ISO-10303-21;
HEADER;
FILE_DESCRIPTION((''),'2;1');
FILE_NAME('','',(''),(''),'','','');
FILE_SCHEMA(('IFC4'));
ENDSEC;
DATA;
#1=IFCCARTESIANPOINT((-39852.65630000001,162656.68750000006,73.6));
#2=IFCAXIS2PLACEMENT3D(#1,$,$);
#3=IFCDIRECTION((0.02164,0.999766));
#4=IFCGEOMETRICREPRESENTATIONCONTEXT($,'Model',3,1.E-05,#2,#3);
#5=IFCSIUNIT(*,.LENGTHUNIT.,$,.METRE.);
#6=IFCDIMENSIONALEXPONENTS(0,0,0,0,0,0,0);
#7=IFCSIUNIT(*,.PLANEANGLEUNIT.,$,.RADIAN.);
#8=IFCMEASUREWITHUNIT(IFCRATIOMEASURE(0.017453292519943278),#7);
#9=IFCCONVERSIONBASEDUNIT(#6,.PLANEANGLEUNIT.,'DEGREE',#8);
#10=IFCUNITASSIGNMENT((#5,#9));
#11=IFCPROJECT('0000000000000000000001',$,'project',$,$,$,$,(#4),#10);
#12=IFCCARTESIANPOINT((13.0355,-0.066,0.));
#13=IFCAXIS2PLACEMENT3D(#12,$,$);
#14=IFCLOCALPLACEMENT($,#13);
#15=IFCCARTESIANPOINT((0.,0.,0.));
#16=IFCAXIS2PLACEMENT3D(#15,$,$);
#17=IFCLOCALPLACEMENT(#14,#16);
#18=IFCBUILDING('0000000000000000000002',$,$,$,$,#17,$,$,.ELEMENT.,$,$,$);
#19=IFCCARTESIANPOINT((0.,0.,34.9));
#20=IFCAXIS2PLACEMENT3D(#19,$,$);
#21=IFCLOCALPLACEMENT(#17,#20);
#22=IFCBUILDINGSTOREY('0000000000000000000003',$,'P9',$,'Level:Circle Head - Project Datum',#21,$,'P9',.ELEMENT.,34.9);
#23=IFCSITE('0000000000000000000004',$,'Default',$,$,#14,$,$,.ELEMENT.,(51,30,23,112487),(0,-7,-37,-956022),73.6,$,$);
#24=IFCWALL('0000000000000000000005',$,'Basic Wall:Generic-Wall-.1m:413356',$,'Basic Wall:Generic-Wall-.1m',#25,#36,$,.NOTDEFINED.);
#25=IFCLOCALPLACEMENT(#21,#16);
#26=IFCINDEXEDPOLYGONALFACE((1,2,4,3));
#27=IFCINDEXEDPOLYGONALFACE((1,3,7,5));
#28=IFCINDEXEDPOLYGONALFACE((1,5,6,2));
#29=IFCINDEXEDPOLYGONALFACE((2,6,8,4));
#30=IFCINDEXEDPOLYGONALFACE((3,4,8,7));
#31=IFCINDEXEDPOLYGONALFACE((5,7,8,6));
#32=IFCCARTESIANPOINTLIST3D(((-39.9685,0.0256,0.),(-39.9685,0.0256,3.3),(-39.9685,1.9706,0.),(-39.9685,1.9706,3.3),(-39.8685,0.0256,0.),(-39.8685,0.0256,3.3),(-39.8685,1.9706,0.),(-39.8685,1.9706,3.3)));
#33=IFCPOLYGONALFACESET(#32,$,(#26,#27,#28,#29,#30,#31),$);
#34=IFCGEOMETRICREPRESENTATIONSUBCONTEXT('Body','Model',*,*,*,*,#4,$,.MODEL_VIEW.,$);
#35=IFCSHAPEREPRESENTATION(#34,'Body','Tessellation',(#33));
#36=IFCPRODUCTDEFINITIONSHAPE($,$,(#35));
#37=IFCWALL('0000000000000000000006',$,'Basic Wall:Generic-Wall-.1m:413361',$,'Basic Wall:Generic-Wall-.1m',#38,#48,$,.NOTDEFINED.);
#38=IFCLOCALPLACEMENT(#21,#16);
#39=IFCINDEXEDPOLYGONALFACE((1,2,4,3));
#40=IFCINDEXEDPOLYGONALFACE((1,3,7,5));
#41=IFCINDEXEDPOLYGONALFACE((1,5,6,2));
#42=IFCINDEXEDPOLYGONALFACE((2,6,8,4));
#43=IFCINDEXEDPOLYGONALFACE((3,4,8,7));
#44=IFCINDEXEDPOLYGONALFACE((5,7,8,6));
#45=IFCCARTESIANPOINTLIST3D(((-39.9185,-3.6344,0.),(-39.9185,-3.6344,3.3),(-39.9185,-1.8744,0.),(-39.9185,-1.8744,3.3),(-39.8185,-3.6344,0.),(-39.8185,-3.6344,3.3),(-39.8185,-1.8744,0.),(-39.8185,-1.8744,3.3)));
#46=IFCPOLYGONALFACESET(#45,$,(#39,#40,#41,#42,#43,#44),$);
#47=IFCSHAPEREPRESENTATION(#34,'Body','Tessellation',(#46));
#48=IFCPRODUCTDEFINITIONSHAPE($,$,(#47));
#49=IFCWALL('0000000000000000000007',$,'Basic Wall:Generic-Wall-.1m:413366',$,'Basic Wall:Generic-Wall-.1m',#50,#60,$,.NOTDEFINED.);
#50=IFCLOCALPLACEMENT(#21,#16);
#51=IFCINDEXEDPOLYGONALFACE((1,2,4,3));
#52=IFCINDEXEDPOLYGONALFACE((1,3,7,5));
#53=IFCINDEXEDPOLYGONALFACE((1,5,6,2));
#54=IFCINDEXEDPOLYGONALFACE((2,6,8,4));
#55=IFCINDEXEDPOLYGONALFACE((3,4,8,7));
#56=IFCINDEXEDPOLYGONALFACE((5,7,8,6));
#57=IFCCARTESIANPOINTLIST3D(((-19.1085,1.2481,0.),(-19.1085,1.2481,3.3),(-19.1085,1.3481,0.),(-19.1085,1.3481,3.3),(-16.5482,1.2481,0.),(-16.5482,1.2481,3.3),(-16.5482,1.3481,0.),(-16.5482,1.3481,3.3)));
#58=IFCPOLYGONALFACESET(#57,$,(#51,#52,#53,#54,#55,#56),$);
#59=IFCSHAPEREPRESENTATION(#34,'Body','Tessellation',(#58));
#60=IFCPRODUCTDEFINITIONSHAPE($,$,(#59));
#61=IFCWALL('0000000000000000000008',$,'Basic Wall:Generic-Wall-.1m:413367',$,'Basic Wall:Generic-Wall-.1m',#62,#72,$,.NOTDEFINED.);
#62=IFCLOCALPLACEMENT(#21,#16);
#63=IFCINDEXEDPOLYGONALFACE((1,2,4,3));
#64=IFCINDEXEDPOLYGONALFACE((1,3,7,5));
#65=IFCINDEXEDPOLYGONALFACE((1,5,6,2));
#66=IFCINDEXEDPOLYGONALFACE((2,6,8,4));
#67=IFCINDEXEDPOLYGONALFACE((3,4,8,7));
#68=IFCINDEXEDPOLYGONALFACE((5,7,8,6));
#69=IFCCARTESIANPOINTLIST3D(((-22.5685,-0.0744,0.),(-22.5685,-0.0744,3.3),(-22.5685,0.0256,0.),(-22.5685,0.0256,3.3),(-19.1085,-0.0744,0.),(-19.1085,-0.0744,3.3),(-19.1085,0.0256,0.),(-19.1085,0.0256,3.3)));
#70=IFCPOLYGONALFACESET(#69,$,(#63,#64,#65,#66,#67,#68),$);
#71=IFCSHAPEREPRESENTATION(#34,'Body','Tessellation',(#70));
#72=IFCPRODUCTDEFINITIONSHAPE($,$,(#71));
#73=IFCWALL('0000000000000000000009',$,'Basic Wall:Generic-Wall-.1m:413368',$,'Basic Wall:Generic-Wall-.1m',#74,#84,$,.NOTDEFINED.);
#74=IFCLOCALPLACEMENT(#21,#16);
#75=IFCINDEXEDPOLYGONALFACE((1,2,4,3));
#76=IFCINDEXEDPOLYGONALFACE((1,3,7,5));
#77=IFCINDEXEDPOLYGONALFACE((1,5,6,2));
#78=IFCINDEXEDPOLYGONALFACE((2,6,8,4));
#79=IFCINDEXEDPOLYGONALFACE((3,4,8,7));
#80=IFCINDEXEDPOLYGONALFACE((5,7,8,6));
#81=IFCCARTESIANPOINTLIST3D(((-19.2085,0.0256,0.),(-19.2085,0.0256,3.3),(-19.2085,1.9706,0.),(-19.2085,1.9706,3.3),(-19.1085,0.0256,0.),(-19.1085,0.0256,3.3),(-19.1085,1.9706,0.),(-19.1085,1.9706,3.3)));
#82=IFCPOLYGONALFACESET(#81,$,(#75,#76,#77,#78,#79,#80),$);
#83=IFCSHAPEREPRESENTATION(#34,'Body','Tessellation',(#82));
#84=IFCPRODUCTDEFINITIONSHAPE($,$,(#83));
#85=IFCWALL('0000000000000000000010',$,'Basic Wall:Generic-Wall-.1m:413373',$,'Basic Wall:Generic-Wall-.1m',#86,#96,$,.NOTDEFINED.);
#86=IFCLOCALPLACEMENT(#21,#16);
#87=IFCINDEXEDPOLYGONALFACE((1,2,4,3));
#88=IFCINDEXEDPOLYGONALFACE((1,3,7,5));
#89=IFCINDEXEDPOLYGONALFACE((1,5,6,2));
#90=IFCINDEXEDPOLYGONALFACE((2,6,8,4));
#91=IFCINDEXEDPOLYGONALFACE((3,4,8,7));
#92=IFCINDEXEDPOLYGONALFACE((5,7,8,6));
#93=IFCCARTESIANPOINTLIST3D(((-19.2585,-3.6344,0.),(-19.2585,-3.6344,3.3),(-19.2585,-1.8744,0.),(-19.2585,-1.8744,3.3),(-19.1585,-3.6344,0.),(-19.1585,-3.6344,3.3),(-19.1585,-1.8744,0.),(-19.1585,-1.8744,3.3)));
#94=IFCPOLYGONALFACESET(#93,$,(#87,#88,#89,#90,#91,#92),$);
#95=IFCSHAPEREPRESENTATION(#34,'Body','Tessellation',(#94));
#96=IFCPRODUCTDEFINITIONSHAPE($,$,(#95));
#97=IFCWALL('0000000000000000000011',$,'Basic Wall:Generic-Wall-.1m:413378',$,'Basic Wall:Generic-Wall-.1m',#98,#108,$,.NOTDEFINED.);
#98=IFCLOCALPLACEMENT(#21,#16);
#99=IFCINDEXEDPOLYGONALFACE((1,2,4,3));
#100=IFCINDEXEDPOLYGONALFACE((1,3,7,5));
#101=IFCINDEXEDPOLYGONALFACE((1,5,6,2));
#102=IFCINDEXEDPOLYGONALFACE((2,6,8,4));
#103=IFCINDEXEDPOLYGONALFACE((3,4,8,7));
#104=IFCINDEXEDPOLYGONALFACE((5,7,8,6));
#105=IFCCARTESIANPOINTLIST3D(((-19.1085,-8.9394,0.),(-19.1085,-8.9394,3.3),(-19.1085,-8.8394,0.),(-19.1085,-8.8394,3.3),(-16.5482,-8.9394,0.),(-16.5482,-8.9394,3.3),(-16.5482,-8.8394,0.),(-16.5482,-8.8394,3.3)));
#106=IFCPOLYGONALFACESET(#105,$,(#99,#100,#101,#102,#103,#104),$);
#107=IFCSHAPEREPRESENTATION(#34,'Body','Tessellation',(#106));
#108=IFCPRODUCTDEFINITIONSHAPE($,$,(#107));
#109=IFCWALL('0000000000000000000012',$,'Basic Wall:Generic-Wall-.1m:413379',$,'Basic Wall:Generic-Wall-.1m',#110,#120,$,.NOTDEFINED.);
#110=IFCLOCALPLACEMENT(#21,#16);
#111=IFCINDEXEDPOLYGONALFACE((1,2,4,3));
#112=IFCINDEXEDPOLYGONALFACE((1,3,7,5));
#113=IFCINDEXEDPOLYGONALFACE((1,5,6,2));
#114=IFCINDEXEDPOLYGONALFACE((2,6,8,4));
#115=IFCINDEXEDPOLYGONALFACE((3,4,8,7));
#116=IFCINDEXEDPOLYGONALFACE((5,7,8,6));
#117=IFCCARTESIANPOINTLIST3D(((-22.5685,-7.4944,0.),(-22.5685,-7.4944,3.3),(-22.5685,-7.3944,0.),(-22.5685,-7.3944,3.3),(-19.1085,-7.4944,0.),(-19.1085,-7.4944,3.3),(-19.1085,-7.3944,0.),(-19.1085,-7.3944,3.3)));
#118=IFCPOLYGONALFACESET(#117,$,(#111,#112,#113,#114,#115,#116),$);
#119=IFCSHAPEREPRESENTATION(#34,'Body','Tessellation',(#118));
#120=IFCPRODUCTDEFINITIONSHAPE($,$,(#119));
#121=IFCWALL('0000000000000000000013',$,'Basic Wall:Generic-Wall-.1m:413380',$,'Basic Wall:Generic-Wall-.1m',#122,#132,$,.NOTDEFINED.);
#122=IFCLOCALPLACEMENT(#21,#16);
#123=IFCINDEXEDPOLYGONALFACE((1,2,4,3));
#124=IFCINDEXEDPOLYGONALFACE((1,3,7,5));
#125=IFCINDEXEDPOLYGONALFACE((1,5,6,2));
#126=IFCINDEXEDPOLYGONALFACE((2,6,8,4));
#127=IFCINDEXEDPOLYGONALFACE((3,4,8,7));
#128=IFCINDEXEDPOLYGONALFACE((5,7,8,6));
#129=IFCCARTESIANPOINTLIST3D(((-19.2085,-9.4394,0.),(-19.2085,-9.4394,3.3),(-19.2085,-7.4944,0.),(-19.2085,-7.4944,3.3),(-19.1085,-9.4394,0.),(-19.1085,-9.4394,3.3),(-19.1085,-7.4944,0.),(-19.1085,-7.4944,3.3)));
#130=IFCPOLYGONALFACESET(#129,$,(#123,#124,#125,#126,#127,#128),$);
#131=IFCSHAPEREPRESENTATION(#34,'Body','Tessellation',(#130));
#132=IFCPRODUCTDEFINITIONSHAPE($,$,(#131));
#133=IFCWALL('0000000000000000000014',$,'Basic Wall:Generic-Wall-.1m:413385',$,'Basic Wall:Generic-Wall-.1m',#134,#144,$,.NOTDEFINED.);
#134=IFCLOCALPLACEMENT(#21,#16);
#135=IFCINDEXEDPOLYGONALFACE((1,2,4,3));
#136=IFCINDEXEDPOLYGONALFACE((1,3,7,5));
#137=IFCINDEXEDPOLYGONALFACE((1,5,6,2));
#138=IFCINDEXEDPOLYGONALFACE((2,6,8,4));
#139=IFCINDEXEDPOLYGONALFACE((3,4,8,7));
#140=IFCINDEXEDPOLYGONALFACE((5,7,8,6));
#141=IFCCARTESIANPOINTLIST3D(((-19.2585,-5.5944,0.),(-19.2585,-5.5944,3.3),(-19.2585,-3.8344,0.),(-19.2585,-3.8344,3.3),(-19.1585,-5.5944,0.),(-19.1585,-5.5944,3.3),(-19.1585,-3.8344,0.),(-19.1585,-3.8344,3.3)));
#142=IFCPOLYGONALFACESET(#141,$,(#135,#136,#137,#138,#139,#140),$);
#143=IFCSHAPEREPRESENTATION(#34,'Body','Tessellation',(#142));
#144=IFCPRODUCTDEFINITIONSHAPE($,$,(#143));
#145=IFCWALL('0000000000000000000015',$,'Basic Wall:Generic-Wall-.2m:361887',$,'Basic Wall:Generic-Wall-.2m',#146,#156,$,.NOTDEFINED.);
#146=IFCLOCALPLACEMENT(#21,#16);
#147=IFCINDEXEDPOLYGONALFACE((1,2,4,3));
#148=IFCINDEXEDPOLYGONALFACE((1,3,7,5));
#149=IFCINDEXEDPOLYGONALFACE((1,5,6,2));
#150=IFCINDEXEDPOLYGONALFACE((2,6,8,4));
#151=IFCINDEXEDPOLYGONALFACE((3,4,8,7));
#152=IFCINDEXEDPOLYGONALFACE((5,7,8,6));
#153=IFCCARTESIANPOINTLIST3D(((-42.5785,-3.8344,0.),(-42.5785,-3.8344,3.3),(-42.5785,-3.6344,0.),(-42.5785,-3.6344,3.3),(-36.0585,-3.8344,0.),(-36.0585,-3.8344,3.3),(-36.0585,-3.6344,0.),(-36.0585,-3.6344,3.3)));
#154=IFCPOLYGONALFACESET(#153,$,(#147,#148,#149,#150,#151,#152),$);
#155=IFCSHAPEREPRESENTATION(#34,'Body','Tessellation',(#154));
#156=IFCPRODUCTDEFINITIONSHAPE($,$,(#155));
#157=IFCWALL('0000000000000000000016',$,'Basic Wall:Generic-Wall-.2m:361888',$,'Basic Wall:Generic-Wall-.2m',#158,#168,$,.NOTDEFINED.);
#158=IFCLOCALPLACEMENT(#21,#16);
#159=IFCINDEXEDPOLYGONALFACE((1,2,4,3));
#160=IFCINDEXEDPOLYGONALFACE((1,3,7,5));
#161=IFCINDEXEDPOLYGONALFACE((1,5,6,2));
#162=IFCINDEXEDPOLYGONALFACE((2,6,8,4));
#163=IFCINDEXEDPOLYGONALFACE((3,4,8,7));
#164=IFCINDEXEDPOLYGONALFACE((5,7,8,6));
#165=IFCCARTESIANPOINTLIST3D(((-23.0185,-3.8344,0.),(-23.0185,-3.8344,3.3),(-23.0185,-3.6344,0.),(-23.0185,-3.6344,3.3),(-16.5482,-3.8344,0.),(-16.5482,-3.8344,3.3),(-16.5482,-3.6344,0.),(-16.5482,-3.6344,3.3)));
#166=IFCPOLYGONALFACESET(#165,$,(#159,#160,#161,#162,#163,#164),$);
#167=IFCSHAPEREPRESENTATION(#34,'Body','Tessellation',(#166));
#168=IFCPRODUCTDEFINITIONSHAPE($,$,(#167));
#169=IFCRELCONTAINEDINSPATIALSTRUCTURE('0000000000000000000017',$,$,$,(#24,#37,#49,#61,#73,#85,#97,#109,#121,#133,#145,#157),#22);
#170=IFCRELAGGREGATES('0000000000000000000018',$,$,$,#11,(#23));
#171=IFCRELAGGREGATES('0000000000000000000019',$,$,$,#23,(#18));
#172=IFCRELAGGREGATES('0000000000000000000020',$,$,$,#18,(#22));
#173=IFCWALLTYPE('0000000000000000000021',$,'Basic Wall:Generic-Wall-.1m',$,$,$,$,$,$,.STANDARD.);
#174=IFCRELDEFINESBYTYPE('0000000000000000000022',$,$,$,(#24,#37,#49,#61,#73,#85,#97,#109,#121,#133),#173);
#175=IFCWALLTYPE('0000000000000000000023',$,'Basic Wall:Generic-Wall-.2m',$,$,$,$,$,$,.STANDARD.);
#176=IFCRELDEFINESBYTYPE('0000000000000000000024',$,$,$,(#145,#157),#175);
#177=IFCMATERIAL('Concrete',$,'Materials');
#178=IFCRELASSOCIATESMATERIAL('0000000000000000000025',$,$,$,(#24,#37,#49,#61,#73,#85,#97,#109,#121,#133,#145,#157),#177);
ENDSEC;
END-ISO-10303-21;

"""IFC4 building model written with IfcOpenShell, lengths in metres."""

from ifc_helpers import new_model, entity, si_unit, converted_unit, direction, frame, origin, place, context, subcontext, project, spatial, indexed_curve, outline, extrude, material, type_object, element, save


model = new_model("IFC4")

# Units and contexts
model_context = context("Model", 3, precision=1e-05, world=frame((-39852.65630000001, 162656.68750000006, 73.6)), true_north=direction((0.02164, 0.999766)))
body_context = subcontext(model_context, "Body", "Model", "MODEL_VIEW")
ifc_project = project(units=[si_unit("LENGTHUNIT", "METRE"), converted_unit("PLANEANGLEUNIT", "DEGREE", entity("IfcRatioMeasure", 0.017453292519943278), si_unit("PLANEANGLEUNIT", "RADIAN"), dimensions=[0, 0, 0, 0, 0, 0, 0])], contexts=[model_context])

# Site, building, storey
site_placement = place(None, frame((13.0355, -0.066, 0.0)))
site = spatial("IfcSite", under=ifc_project, at=site_placement, Name="Default", CompositionType="ELEMENT", RefLatitude=(51, 30, 23, 112487), RefLongitude=(0, -7, -37, -956022), RefElevation=73.6)
building_placement = place(site_placement, origin())
building = spatial("IfcBuilding", under=site, at=building_placement, CompositionType="ELEMENT")
storey_placement = place(building_placement, frame((0.0, 0.0, 34.9)))
storey = spatial("IfcBuildingStorey", under=building, at=storey_placement, Name="P9", ObjectType="Level:Circle Head - Project Datum", LongName="P9", CompositionType="ELEMENT", Elevation=34.9)

# Shared definitions
ifc_material = material(Name="Concrete", Category="Materials")

# Walls
wall_type_1 = type_object("IfcWallType", Name="Basic Wall:Generic-Wall-.1m", PredefinedType="STANDARD")
wall_1_placement = place(storey_placement, frame((-39.9185, 0.0256, 0.0), z_axis=(0.0, 0.0, 1.0), x_axis=(0.0, 1.0, 0.0)))
element("IfcWall", 1, at=wall_1_placement, inside=storey, type_object=wall_type_1, material=ifc_material, Name="Basic Wall:Generic-Wall-.1m:413356", ObjectType="Basic Wall:Generic-Wall-.1m", PredefinedType="NOTDEFINED", context=body_context, shape_type="SweptSolid", body=[
    extrude(outline(indexed_curve([(1.945, 0.05), (0.0, 0.05), (0.0, -0.05), (1.945, -0.05), (1.945, 0.05)], self_intersect=False)), origin(), (0.0, 0.0, 1.0), 3.3),
])
wall_2_placement = place(storey_placement, frame((-39.8685, -1.8744, 0.0), z_axis=(0.0, 0.0, 1.0), x_axis=(0.0, -1.0, 0.0)))
element("IfcWall", 2, at=wall_2_placement, inside=storey, type_object=wall_type_1, material=ifc_material, Name="Basic Wall:Generic-Wall-.1m:413361", ObjectType="Basic Wall:Generic-Wall-.1m", PredefinedType="NOTDEFINED", context=body_context, shape_type="SweptSolid", body=[
    extrude(outline(indexed_curve([(1.76, 0.05), (0.0, 0.05), (0.0, -0.05), (1.76, -0.05), (1.76, 0.05)], self_intersect=False)), origin(), (0.0, 0.0, 1.0), 3.3),
])
wall_3_placement = place(storey_placement, frame((-19.1085, 1.2981, 0.0)))
element("IfcWall", 3, at=wall_3_placement, inside=storey, type_object=wall_type_1, material=ifc_material, Name="Basic Wall:Generic-Wall-.1m:413366", ObjectType="Basic Wall:Generic-Wall-.1m", PredefinedType="NOTDEFINED", context=body_context, shape_type="SweptSolid", body=[
    extrude(outline(indexed_curve([(2.5602, 0.05), (0.0, 0.05), (0.0, -0.05), (2.5602, -0.05), (2.5602, 0.05)], self_intersect=False)), origin(), (0.0, 0.0, 1.0), 3.3),
])
wall_4_placement = place(storey_placement, frame((-22.5685, -0.0244, 0.0)))
element("IfcWall", 4, at=wall_4_placement, inside=storey, type_object=wall_type_1, material=ifc_material, Name="Basic Wall:Generic-Wall-.1m:413367", ObjectType="Basic Wall:Generic-Wall-.1m", PredefinedType="NOTDEFINED", context=body_context, shape_type="SweptSolid", body=[
    extrude(outline(indexed_curve([(3.46, 0.05), (0.0, 0.05), (0.0, -0.05), (3.46, -0.05), (3.46, 0.05)], self_intersect=False)), origin(), (0.0, 0.0, 1.0), 3.3),
])
wall_5_placement = place(storey_placement, frame((-19.1585, 0.0256, 0.0), z_axis=(0.0, 0.0, 1.0), x_axis=(0.0, 1.0, 0.0)))
element("IfcWall", 5, at=wall_5_placement, inside=storey, type_object=wall_type_1, material=ifc_material, Name="Basic Wall:Generic-Wall-.1m:413368", ObjectType="Basic Wall:Generic-Wall-.1m", PredefinedType="NOTDEFINED", context=body_context, shape_type="SweptSolid", body=[
    extrude(outline(indexed_curve([(1.945, 0.05), (0.0, 0.05), (0.0, -0.05), (1.945, -0.05), (1.945, 0.05)], self_intersect=False)), origin(), (0.0, 0.0, 1.0), 3.3),
])
wall_6_placement = place(storey_placement, frame((-19.2085, -1.8744, 0.0), z_axis=(0.0, 0.0, 1.0), x_axis=(0.0, -1.0, 0.0)))
element("IfcWall", 6, at=wall_6_placement, inside=storey, type_object=wall_type_1, material=ifc_material, Name="Basic Wall:Generic-Wall-.1m:413373", ObjectType="Basic Wall:Generic-Wall-.1m", PredefinedType="NOTDEFINED", context=body_context, shape_type="SweptSolid", body=[
    extrude(outline(indexed_curve([(1.76, 0.05), (0.0, 0.05), (0.0, -0.05), (1.76, -0.05), (1.76, 0.05)], self_intersect=False)), origin(), (0.0, 0.0, 1.0), 3.3),
])
wall_7_placement = place(storey_placement, frame((-19.1085, -8.8894, 0.0)))
element("IfcWall", 7, at=wall_7_placement, inside=storey, type_object=wall_type_1, material=ifc_material, Name="Basic Wall:Generic-Wall-.1m:413378", ObjectType="Basic Wall:Generic-Wall-.1m", PredefinedType="NOTDEFINED", context=body_context, shape_type="SweptSolid", body=[
    extrude(outline(indexed_curve([(2.5602, 0.05), (0.0, 0.05), (0.0, -0.05), (2.5602, -0.05), (2.5602, 0.05)], self_intersect=False)), origin(), (0.0, 0.0, 1.0), 3.3),
])
wall_8_placement = place(storey_placement, frame((-22.5685, -7.4444, 0.0)))
element("IfcWall", 8, at=wall_8_placement, inside=storey, type_object=wall_type_1, material=ifc_material, Name="Basic Wall:Generic-Wall-.1m:413379", ObjectType="Basic Wall:Generic-Wall-.1m", PredefinedType="NOTDEFINED", context=body_context, shape_type="SweptSolid", body=[
    extrude(outline(indexed_curve([(3.46, 0.05), (0.0, 0.05), (0.0, -0.05), (3.46, -0.05), (3.46, 0.05)], self_intersect=False)), origin(), (0.0, 0.0, 1.0), 3.3),
])
wall_9_placement = place(storey_placement, frame((-19.1585, -7.4944, 0.0), z_axis=(0.0, 0.0, 1.0), x_axis=(0.0, -1.0, 0.0)))
element("IfcWall", 9, at=wall_9_placement, inside=storey, type_object=wall_type_1, material=ifc_material, Name="Basic Wall:Generic-Wall-.1m:413380", ObjectType="Basic Wall:Generic-Wall-.1m", PredefinedType="NOTDEFINED", context=body_context, shape_type="SweptSolid", body=[
    extrude(outline(indexed_curve([(1.945, 0.05), (0.0, 0.05), (0.0, -0.05), (1.945, -0.05), (1.945, 0.05)], self_intersect=False)), origin(), (0.0, 0.0, 1.0), 3.3),
])
wall_10_placement = place(storey_placement, frame((-19.2085, -5.5944, 0.0), z_axis=(0.0, 0.0, 1.0), x_axis=(0.0, 1.0, 0.0)))
element("IfcWall", 10, at=wall_10_placement, inside=storey, type_object=wall_type_1, material=ifc_material, Name="Basic Wall:Generic-Wall-.1m:413385", ObjectType="Basic Wall:Generic-Wall-.1m", PredefinedType="NOTDEFINED", context=body_context, shape_type="SweptSolid", body=[
    extrude(outline(indexed_curve([(1.76, 0.05), (0.0, 0.05), (0.0, -0.05), (1.76, -0.05), (1.76, 0.05)], self_intersect=False)), origin(), (0.0, 0.0, 1.0), 3.3),
])
wall_type_2 = type_object("IfcWallType", Name="Basic Wall:Generic-Wall-.2m", PredefinedType="STANDARD")
wall_11_placement = place(storey_placement, frame((-36.0585, -3.7344, 0.0), z_axis=(0.0, 0.0, 1.0), x_axis=(-1.0, 0.0, 0.0)))
element("IfcWall", 11, at=wall_11_placement, inside=storey, type_object=wall_type_2, material=ifc_material, Name="Basic Wall:Generic-Wall-.2m:361887", ObjectType="Basic Wall:Generic-Wall-.2m", PredefinedType="NOTDEFINED", context=body_context, shape_type="SweptSolid", body=[
    extrude(outline(indexed_curve([(6.52, 0.1), (0.0, 0.1), (0.0, -0.1), (6.52, -0.1), (6.52, 0.1)], self_intersect=False)), origin(), (0.0, 0.0, 1.0), 3.3),
])
wall_12_placement = place(storey_placement, frame((-23.0185, -3.7344, 0.0)))
element("IfcWall", 12, at=wall_12_placement, inside=storey, type_object=wall_type_2, material=ifc_material, Name="Basic Wall:Generic-Wall-.2m:361888", ObjectType="Basic Wall:Generic-Wall-.2m", PredefinedType="NOTDEFINED", context=body_context, shape_type="SweptSolid", body=[
    extrude(outline(indexed_curve([(6.4702, 0.1), (0.0, 0.1), (0.0, -0.1), (6.4702, -0.1), (6.4702, 0.1)], self_intersect=False)), origin(), (0.0, 0.0, 1.0), 3.3),
])

save(model, "model.ifc")
